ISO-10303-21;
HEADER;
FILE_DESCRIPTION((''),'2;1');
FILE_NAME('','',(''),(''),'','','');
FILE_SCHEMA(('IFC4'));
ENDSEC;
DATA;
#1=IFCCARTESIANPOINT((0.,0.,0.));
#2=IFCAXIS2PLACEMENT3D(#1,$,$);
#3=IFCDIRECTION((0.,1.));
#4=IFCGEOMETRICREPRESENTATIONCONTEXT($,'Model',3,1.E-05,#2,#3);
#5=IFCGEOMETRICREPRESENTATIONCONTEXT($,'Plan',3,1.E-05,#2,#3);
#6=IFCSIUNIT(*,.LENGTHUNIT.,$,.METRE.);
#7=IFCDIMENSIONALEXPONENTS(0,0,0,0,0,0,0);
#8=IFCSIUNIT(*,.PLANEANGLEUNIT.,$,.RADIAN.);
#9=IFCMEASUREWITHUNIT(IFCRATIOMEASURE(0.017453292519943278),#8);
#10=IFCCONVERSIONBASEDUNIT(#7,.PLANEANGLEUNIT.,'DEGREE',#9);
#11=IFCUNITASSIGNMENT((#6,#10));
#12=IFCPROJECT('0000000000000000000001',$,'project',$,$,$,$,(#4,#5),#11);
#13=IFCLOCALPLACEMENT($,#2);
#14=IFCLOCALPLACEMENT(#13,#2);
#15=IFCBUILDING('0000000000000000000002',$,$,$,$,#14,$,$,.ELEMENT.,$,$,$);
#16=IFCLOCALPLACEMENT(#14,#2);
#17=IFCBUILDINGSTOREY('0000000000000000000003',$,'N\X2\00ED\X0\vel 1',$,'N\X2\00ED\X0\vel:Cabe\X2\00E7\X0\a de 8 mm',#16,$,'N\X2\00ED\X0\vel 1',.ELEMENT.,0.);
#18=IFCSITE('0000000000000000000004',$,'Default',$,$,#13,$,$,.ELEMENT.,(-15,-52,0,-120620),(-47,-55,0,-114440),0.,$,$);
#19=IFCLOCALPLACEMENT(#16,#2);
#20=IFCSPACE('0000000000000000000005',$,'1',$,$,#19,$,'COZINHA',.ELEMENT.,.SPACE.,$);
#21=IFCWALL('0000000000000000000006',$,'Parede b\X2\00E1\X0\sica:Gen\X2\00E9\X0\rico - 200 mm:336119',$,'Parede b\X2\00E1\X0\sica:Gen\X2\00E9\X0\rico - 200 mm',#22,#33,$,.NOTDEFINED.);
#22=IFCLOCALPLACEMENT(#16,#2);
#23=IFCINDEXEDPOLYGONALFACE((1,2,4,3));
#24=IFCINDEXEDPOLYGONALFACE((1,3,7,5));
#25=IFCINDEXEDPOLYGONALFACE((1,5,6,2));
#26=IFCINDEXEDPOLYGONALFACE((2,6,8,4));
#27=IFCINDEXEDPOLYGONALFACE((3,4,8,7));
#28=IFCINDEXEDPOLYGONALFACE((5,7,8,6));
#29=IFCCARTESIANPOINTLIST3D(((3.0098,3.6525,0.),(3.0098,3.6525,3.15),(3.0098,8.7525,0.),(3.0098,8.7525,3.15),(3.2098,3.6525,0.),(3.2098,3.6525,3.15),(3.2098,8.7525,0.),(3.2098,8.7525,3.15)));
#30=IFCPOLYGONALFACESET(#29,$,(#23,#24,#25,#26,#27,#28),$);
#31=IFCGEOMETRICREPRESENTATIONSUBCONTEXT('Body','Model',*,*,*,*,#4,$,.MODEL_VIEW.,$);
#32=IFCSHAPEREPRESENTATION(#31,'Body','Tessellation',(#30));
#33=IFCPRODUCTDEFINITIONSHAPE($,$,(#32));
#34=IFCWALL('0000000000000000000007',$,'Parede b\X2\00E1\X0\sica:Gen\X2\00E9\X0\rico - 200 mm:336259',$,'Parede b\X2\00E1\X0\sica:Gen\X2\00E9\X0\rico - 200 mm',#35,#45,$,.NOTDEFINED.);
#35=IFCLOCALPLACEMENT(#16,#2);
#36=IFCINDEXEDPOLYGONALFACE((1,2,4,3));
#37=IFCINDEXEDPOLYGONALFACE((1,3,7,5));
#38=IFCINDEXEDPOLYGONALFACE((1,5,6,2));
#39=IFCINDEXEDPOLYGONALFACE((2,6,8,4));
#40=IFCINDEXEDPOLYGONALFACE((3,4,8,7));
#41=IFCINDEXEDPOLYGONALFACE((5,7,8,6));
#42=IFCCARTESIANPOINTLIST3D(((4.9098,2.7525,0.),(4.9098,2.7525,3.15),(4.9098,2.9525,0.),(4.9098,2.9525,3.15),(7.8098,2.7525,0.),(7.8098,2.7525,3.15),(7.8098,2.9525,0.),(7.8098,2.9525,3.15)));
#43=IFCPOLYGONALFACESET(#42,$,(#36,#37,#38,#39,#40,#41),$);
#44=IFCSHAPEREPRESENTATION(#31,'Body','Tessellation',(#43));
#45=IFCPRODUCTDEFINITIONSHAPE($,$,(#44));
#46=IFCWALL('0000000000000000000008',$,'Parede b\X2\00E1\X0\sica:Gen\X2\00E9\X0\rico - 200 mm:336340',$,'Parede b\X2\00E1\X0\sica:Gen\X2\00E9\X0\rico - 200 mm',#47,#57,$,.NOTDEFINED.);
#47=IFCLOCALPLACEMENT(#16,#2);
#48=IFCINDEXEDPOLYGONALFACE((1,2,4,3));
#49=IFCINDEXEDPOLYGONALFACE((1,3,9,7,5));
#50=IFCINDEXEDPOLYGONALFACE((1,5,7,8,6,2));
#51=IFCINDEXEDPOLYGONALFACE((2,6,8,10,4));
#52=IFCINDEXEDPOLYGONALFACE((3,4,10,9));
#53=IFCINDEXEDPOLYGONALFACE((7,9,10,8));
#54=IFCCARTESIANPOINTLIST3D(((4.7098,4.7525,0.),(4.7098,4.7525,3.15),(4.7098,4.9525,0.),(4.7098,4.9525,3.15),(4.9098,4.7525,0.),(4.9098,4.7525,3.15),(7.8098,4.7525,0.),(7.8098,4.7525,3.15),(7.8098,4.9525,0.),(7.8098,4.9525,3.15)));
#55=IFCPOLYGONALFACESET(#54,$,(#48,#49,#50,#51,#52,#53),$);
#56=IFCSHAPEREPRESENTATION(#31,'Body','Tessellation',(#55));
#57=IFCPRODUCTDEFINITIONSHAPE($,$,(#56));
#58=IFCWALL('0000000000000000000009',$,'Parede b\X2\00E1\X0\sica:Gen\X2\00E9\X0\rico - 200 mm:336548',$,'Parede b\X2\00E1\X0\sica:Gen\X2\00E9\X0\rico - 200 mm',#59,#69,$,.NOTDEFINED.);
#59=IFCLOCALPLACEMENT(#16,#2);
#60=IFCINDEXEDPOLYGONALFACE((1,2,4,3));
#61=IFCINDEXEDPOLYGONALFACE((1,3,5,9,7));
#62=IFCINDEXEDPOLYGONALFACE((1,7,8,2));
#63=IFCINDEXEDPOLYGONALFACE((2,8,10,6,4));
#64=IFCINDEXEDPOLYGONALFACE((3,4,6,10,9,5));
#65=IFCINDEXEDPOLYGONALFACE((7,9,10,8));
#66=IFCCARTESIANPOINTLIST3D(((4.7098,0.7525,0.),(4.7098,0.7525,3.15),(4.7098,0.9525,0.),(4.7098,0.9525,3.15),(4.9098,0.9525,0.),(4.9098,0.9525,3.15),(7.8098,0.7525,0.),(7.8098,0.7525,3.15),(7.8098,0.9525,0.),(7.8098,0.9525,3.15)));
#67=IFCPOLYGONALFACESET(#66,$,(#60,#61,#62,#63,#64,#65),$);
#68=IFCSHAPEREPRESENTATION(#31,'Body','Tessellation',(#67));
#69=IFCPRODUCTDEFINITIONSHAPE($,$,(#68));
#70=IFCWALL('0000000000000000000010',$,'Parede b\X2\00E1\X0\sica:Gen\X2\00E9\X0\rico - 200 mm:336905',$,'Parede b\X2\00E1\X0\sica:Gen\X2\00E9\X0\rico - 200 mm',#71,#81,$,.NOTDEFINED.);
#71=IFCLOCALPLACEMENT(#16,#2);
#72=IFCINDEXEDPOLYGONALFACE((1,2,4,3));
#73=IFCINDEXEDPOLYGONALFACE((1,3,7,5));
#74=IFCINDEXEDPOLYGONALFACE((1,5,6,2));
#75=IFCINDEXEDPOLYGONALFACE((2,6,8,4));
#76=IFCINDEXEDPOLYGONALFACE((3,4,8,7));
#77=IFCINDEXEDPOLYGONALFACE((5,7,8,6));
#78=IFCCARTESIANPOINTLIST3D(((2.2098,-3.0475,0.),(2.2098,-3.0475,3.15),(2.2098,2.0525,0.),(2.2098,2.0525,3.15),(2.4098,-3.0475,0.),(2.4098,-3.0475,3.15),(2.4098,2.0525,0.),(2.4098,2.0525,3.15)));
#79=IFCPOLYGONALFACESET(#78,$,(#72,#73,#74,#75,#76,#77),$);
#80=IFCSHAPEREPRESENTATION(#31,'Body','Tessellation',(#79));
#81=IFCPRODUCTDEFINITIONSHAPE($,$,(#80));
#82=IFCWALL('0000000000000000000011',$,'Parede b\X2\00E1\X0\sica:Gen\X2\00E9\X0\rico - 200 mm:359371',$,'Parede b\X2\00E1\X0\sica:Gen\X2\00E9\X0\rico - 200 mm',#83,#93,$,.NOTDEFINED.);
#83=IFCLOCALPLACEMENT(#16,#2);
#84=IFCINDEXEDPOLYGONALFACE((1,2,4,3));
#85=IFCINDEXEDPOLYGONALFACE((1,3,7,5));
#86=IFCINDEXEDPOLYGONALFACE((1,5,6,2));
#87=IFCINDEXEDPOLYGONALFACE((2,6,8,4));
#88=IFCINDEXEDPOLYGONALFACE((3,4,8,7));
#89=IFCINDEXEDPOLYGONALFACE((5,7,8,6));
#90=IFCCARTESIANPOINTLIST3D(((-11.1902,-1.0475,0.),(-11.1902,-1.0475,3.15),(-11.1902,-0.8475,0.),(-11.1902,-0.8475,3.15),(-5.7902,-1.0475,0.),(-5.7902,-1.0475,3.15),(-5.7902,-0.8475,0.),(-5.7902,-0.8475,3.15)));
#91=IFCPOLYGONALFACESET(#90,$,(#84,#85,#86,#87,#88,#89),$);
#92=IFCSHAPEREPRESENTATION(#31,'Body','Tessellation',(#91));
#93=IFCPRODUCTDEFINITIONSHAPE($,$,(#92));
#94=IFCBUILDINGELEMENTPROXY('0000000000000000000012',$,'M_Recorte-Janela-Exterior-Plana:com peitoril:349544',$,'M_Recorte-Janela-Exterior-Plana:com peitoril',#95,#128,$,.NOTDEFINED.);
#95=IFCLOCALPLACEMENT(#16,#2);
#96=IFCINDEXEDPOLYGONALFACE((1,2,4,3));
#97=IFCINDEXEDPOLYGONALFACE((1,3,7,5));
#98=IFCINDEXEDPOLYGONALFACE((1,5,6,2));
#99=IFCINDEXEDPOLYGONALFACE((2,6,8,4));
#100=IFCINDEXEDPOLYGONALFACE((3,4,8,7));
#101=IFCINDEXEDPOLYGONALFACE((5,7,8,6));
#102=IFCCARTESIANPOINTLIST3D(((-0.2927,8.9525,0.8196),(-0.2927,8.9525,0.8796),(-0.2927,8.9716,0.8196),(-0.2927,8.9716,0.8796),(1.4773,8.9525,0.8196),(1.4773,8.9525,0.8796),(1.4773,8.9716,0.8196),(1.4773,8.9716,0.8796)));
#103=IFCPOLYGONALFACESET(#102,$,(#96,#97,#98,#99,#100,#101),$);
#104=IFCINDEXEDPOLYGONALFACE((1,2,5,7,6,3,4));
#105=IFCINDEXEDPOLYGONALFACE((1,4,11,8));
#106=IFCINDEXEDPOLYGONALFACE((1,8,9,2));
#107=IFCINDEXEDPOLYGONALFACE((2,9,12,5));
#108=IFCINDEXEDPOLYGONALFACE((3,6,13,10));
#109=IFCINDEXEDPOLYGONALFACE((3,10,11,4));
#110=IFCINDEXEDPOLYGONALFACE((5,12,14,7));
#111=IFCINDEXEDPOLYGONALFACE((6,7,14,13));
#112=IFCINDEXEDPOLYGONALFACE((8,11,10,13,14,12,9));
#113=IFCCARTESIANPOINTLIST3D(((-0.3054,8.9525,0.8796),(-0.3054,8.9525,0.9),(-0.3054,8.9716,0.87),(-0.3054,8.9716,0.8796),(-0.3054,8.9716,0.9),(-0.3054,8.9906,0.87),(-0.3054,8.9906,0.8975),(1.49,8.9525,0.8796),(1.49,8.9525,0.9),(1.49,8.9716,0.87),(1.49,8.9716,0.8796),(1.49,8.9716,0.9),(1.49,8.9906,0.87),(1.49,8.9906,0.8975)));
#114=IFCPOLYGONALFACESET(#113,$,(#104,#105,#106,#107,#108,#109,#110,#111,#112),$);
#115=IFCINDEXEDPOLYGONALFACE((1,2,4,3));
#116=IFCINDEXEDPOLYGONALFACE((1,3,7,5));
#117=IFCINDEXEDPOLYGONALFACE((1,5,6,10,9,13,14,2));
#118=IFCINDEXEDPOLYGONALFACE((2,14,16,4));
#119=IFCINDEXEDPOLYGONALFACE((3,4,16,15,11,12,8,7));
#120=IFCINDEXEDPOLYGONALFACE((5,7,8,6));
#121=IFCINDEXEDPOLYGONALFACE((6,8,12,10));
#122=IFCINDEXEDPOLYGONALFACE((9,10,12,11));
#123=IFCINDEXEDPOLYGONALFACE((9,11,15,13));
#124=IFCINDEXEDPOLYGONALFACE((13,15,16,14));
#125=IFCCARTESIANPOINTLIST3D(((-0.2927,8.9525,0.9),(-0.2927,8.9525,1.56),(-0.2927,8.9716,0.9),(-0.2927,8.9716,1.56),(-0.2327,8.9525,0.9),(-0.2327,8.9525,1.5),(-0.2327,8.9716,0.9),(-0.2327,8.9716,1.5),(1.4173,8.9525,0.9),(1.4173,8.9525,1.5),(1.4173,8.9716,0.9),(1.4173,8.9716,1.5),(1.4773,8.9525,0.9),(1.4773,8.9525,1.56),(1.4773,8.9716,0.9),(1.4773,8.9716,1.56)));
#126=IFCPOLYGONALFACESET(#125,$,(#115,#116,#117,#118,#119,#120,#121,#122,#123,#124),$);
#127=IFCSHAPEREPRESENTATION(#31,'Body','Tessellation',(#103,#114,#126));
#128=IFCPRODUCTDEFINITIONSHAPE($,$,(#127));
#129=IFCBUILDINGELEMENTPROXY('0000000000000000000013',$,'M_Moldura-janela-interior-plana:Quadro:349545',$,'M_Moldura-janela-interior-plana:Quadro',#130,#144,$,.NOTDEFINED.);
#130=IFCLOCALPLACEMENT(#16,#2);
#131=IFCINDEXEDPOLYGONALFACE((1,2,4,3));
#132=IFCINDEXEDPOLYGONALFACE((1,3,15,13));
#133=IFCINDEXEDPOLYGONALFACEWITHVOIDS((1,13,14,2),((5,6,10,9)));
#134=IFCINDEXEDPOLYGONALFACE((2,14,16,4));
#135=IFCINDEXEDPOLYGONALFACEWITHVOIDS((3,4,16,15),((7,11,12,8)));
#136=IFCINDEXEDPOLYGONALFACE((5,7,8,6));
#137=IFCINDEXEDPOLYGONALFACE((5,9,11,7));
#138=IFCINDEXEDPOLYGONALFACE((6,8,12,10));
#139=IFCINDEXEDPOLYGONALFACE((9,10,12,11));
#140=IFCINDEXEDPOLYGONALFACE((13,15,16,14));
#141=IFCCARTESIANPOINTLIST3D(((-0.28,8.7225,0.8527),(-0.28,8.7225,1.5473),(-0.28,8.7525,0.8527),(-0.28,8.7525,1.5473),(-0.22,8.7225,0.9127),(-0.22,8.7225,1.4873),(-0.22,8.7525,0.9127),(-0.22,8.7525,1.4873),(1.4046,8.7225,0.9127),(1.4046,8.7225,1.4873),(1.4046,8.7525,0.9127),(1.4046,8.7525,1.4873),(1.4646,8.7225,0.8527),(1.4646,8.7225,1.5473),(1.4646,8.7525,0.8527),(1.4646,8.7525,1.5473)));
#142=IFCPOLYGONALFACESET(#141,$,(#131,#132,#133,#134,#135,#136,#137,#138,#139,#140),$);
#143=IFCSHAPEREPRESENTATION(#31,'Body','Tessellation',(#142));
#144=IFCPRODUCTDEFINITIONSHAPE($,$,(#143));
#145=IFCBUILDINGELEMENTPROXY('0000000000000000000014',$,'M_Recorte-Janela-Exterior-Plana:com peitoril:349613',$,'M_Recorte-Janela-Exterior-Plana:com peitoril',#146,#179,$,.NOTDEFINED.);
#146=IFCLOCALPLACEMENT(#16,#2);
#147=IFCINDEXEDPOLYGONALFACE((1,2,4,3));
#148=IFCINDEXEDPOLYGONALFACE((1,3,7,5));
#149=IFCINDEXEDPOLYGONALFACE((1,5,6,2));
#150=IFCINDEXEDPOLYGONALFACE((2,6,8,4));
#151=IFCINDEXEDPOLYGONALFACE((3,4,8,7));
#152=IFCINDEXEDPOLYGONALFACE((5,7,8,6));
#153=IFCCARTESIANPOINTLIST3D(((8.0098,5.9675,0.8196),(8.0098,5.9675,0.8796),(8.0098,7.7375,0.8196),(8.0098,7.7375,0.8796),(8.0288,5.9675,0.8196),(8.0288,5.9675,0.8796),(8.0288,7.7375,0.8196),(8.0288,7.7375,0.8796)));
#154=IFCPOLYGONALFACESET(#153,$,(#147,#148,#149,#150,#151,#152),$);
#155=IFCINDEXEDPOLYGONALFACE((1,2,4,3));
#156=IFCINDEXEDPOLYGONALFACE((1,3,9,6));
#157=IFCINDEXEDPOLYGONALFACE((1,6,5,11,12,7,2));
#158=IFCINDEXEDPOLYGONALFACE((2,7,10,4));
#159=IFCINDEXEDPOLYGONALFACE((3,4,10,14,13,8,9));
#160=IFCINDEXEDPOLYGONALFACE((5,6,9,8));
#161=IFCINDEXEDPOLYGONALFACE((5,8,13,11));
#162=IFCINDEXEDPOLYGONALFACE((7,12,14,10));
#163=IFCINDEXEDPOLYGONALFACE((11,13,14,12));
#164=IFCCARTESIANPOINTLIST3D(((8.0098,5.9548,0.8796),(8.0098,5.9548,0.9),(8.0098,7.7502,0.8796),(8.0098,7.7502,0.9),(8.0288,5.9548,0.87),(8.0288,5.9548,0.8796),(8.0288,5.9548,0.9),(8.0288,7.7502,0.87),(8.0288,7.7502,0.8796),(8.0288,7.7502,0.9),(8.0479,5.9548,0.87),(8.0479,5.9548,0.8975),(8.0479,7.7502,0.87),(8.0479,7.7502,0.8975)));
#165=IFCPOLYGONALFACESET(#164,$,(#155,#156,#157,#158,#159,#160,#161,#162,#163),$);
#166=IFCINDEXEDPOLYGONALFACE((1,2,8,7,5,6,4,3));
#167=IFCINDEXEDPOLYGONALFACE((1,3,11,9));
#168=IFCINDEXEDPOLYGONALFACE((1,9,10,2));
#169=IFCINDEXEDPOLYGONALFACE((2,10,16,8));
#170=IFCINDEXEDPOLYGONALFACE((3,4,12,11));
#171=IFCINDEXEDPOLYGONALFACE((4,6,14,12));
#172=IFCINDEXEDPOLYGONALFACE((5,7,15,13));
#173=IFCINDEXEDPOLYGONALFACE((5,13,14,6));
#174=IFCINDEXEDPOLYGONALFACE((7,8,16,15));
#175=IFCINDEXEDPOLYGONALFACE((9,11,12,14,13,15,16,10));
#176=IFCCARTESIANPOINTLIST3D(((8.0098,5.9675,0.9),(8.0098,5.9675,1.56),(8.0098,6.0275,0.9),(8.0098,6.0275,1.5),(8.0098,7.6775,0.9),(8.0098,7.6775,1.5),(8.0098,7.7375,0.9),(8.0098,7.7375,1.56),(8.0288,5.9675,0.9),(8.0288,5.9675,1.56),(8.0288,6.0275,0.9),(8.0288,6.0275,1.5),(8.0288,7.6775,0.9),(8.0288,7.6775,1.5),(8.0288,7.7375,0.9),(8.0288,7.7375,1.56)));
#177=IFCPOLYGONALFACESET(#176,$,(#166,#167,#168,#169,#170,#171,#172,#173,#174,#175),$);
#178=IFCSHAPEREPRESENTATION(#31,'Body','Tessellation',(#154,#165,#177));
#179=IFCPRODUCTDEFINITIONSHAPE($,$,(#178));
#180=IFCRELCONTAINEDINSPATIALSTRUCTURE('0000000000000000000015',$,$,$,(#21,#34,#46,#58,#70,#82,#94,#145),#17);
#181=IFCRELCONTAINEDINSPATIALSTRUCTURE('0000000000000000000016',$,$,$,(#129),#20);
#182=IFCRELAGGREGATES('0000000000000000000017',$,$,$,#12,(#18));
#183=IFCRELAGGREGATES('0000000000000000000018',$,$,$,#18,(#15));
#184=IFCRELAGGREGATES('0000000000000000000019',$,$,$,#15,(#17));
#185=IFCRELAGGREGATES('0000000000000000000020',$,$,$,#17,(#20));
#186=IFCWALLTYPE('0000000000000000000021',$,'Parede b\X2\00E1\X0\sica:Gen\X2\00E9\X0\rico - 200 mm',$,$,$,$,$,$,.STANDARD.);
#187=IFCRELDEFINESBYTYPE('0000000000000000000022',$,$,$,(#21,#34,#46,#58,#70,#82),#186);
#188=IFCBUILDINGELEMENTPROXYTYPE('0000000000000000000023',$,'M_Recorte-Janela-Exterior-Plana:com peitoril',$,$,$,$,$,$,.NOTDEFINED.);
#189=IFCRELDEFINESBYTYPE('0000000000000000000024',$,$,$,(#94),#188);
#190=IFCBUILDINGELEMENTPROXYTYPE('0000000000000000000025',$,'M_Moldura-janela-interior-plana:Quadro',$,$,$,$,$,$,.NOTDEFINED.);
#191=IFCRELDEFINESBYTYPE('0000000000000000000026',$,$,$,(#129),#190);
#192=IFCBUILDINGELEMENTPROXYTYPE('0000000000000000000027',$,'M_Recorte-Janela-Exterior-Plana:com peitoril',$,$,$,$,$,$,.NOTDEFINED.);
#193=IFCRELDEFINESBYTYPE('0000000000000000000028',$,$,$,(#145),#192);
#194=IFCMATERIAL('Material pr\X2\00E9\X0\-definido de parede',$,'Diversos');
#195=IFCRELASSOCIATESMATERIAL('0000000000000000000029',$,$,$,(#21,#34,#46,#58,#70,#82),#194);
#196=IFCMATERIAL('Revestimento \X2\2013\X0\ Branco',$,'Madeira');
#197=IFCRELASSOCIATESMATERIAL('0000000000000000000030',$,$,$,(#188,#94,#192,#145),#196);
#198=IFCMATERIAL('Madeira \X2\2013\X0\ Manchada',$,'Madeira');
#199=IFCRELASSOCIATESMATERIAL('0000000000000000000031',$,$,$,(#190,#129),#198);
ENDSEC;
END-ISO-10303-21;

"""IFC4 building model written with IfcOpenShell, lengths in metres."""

from ifc_helpers import new_model, entity, si_unit, converted_unit, direction, frame, origin, place, context, subcontext, project, spatial, indexed_curve, outline, extrude, source, transform, mapped, material, type_object, type_shapes, element, save


model = new_model("IFC4")

# Units and contexts
model_context = context("Model", 3, precision=1e-05, world=origin(), true_north=direction((0.0, 1.0)))
plan_context = context("Plan", 3, precision=1e-05, world=origin(), true_north=direction((0.0, 1.0)))
body_context = subcontext(model_context, "Body", "Model", "MODEL_VIEW")
ifc_project = project(units=[si_unit("LENGTHUNIT", "METRE"), converted_unit("PLANEANGLEUNIT", "DEGREE", entity("IfcRatioMeasure", 0.017453292519943278), si_unit("PLANEANGLEUNIT", "RADIAN"), dimensions=[0, 0, 0, 0, 0, 0, 0])], contexts=[model_context, plan_context])

# Site, building, storey
site_placement = place(None, origin())
site = spatial("IfcSite", under=ifc_project, at=site_placement, Name="Default", CompositionType="ELEMENT", RefLatitude=(-15, -52, 0, -120620), RefLongitude=(-47, -55, 0, -114440), RefElevation=0.0)
building_placement = place(site_placement, origin())
building = spatial("IfcBuilding", under=site, at=building_placement, CompositionType="ELEMENT")
storey_placement = place(building_placement, origin())
storey = spatial("IfcBuildingStorey", under=building, at=storey_placement, Name="Nível 1", ObjectType="Nível:Cabeça de 8 mm", LongName="Nível 1", CompositionType="ELEMENT", Elevation=0.0)

# Walls
ifc_material_1 = material(Name="Material pré-definido de parede", Category="Diversos")
wall_type = type_object("IfcWallType", Name="Parede básica:Genérico - 200 mm", PredefinedType="STANDARD")
wall_1_placement = place(storey_placement, frame((3.1098, 8.7525, 0.0), z_axis=(0.0, 0.0, 1.0), x_axis=(0.0, -1.0, 0.0)))
element("IfcWall", 1, at=wall_1_placement, inside=storey, type_object=wall_type, material=ifc_material_1, Name="Parede básica:Genérico - 200 mm:336119", ObjectType="Parede básica:Genérico - 200 mm", PredefinedType="NOTDEFINED", context=body_context, shape_type="SweptSolid", body=[
    extrude(outline(indexed_curve([(5.1, -0.1), (5.1, 0.1), (0.0, 0.1), (0.0, -0.1), (5.1, -0.1)], self_intersect=False)), origin(), (0.0, 0.0, 1.0), 3.15),
])
wall_2_placement = place(storey_placement, frame((7.8098, 2.8525, 0.0), z_axis=(0.0, 0.0, 1.0), x_axis=(-1.0, 0.0, 0.0)))
element("IfcWall", 2, at=wall_2_placement, inside=storey, type_object=wall_type, material=ifc_material_1, Name="Parede básica:Genérico - 200 mm:336259", ObjectType="Parede básica:Genérico - 200 mm", PredefinedType="NOTDEFINED", context=body_context, shape_type="SweptSolid", body=[
    extrude(outline(indexed_curve([(2.9, -0.1), (2.9, 0.1), (0.0, 0.1), (0.0, -0.1), (2.9, -0.1)], self_intersect=False)), origin(), (0.0, 0.0, 1.0), 3.15),
])
wall_3_placement = place(storey_placement, frame((7.8098, 4.8525, 0.0), z_axis=(0.0, 0.0, 1.0), x_axis=(-1.0, 0.0, 0.0)))
element("IfcWall", 3, at=wall_3_placement, inside=storey, type_object=wall_type, material=ifc_material_1, Name="Parede básica:Genérico - 200 mm:336340", ObjectType="Parede básica:Genérico - 200 mm", PredefinedType="NOTDEFINED", context=body_context, shape_type="SweptSolid", body=[
    extrude(outline(indexed_curve([(3.1, -0.1), (3.1, 0.1), (2.9, 0.1), (0.0, 0.1), (0.0, -0.1), (3.1, -0.1)], self_intersect=False)), origin(), (0.0, 0.0, 1.0), 3.15),
])
wall_4_placement = place(storey_placement, frame((7.8098, 0.8525, 0.0), z_axis=(0.0, 0.0, 1.0), x_axis=(-1.0, 0.0, 0.0)))
element("IfcWall", 4, at=wall_4_placement, inside=storey, type_object=wall_type, material=ifc_material_1, Name="Parede básica:Genérico - 200 mm:336548", ObjectType="Parede básica:Genérico - 200 mm", PredefinedType="NOTDEFINED", context=body_context, shape_type="SweptSolid", body=[
    extrude(outline(indexed_curve([(3.1, -0.1), (3.1, 0.1), (0.0, 0.1), (0.0, -0.1), (2.9, -0.1), (3.1, -0.1)], self_intersect=False)), origin(), (0.0, 0.0, 1.0), 3.15),
])
wall_5_placement = place(storey_placement, frame((2.3098, 2.0525, 0.0), z_axis=(0.0, 0.0, 1.0), x_axis=(0.0, -1.0, 0.0)))
element("IfcWall", 5, at=wall_5_placement, inside=storey, type_object=wall_type, material=ifc_material_1, Name="Parede básica:Genérico - 200 mm:336905", ObjectType="Parede básica:Genérico - 200 mm", PredefinedType="NOTDEFINED", context=body_context, shape_type="SweptSolid", body=[
    extrude(outline(indexed_curve([(5.1, -0.1), (5.1, 0.1), (0.0, 0.1), (0.0, -0.1), (5.1, -0.1)], self_intersect=False)), origin(), (0.0, 0.0, 1.0), 3.15),
])
wall_6_placement = place(storey_placement, frame((-11.1902, -0.9475, 0.0)))
element("IfcWall", 6, at=wall_6_placement, inside=storey, type_object=wall_type, material=ifc_material_1, Name="Parede básica:Genérico - 200 mm:359371", ObjectType="Parede básica:Genérico - 200 mm", PredefinedType="NOTDEFINED", context=body_context, shape_type="SweptSolid", body=[
    extrude(outline(indexed_curve([(5.4, -0.1), (5.4, 0.1), (0.0, 0.1), (0.0, -0.1), (5.4, -0.1)], self_intersect=False)), origin(), (0.0, 0.0, 1.0), 3.15),
])

# Building element proxy
ifc_material_2 = material(Name="Revestimento – Branco", Category="Madeira")
building_element_proxy_type_1 = type_object("IfcBuildingElementProxyType", Name="M_Recorte-Janela-Exterior-Plana:com peitoril", PredefinedType="NOTDEFINED", material=ifc_material_2)
shared_shape_1 = source(origin(), body_context, "Body", "SweptSolid", [
    extrude(outline(indexed_curve([(-0.03, -0.885), (0.03, -0.885), (0.03, 0.885), (-0.03, 0.885), (-0.03, -0.885)], self_intersect=False)), frame((0.0, 0.6504, 0.0), z_axis=(0.0, 0.0, 1.0), x_axis=(0.0, 1.0, 0.0)), (0.0, 0.0, 1.0), 0.019),
    extrude(outline(indexed_curve([(-0.0152, -0.019), (0.0123, -0.019), (0.0148, 0.0), (0.0148, 0.019), (-0.0057, 0.019), (-0.0057, 0.0), (-0.0152, 0.0), (-0.0152, -0.019)], self_intersect=False)), frame((-0.8977, 0.6148, 0.019), z_axis=(1.0, 0.0, 0.0), x_axis=(0.0, -1.0, 0.0)), (0.0, 0.0, 1.0), 1.7954),
    extrude(outline(indexed_curve([(-0.885, -0.345), (0.885, -0.345), (0.885, 0.315), (0.825, 0.315), (0.825, -0.285), (-0.825, -0.285), (-0.825, 0.315), (-0.885, 0.315), (-0.885, -0.345)], self_intersect=False)), frame((0.0, 0.285, 0.0)), (0.0, 0.0, 1.0), 0.019),
])
type_shapes(building_element_proxy_type_1, [shared_shape_1])
proxy_1_placement = place(storey_placement, frame((0.5923, 8.9525, 1.5), z_axis=(0.0, 1.0, 0.0), x_axis=(1.0, 0.0, 0.0)))
element("IfcBuildingElementProxy", 7, at=proxy_1_placement, inside=storey, type_object=building_element_proxy_type_1, material=ifc_material_2, Name="M_Recorte-Janela-Exterior-Plana:com peitoril:349544", ObjectType="M_Recorte-Janela-Exterior-Plana:com peitoril", PredefinedType="NOTDEFINED", context=body_context, shape_type="MappedRepresentation", body=[
    mapped(shared_shape_1, transform((0.0, 0.0, 0.0), scale=1.0)),
])

# Shared definitions
space_1_placement = place(storey_placement, origin())
space_1 = spatial("IfcSpace", under=storey, at=space_1_placement, Name="1", LongName="COZINHA", CompositionType="ELEMENT", PredefinedType="SPACE")

# Building element proxies
ifc_material_3 = material(Name="Madeira – Manchada", Category="Madeira")
building_element_proxy_type_2 = type_object("IfcBuildingElementProxyType", Name="M_Moldura-janela-interior-plana:Quadro", PredefinedType="NOTDEFINED", material=ifc_material_3)
shared_shape_2 = source(origin(), body_context, "Body", "SweptSolid", [
    extrude(outline(indexed_curve([(-0.3473, -0.8723), (0.3473, -0.8723), (0.3473, 0.8723), (-0.3473, 0.8723), (-0.3473, -0.8723)], self_intersect=False), holes=[indexed_curve([(-0.2873, -0.8123), (-0.2873, 0.8123), (0.2873, 0.8123), (0.2873, -0.8123), (-0.2873, -0.8123)], self_intersect=False)]), frame((0.0, 0.3, 0.0), z_axis=(0.0, 0.0, 1.0), x_axis=(0.0, 1.0, 0.0)), (0.0, 0.0, 1.0), 0.03),
])
type_shapes(building_element_proxy_type_2, [shared_shape_2])
proxy_2_placement = place(space_1_placement, frame((0.5923, 8.7525, 1.5), z_axis=(0.0, -1.0, 0.0), x_axis=(-1.0, 0.0, 0.0)))
element("IfcBuildingElementProxy", 8, at=proxy_2_placement, inside=space_1, type_object=building_element_proxy_type_2, material=ifc_material_3, Name="M_Moldura-janela-interior-plana:Quadro:349545", ObjectType="M_Moldura-janela-interior-plana:Quadro", PredefinedType="NOTDEFINED", context=body_context, shape_type="MappedRepresentation", body=[
    mapped(shared_shape_2, transform((0.0, 0.0, 0.0), scale=1.0)),
])
building_element_proxy_type_3 = type_object("IfcBuildingElementProxyType", Name="M_Recorte-Janela-Exterior-Plana:com peitoril", PredefinedType="NOTDEFINED", material=ifc_material_2)
shared_shape_3 = source(origin(), body_context, "Body", "SweptSolid", [
    extrude(outline(indexed_curve([(-0.885, -0.03), (0.885, -0.03), (0.885, 0.03), (-0.885, 0.03), (-0.885, -0.03)], self_intersect=False)), frame((0.0, -0.6504, 0.0), z_axis=(0.0, 0.0, 1.0), x_axis=(-1.0, 0.0, 0.0)), (0.0, 0.0, 1.0), 0.019),
    extrude(outline(indexed_curve([(-0.019, -0.0152), (0.0, -0.0152), (0.0, -0.0057), (0.019, -0.0057), (0.019, 0.0148), (0.0, 0.0148), (-0.019, 0.0123), (-0.019, -0.0152)], self_intersect=False)), frame((-0.8977, -0.6148, 0.019), z_axis=(1.0, 0.0, 0.0), x_axis=(0.0, 0.0, -1.0)), (0.0, 0.0, 1.0), 1.7954),
    extrude(outline(indexed_curve([(-0.345, -0.885), (0.315, -0.885), (0.315, -0.825), (-0.285, -0.825), (-0.285, 0.825), (0.315, 0.825), (0.315, 0.885), (-0.345, 0.885), (-0.345, -0.885)], self_intersect=False)), frame((0.0, -0.285, 0.0), z_axis=(0.0, 0.0, 1.0), x_axis=(0.0, -1.0, 0.0)), (0.0, 0.0, 1.0), 0.019),
])
type_shapes(building_element_proxy_type_3, [shared_shape_3])
proxy_3_placement = place(storey_placement, frame((8.0098, 6.8525, 1.5), z_axis=(1.0, 0.0, 0.0), x_axis=(0.0, 1.0, 0.0)))
element("IfcBuildingElementProxy", 9, at=proxy_3_placement, inside=storey, type_object=building_element_proxy_type_3, material=ifc_material_2, Name="M_Recorte-Janela-Exterior-Plana:com peitoril:349613", ObjectType="M_Recorte-Janela-Exterior-Plana:com peitoril", PredefinedType="NOTDEFINED", context=body_context, shape_type="MappedRepresentation", body=[
    mapped(shared_shape_3, transform((0.0, 0.0, 0.0), scale=1.0)),
])

save(model, "model.ifc")
